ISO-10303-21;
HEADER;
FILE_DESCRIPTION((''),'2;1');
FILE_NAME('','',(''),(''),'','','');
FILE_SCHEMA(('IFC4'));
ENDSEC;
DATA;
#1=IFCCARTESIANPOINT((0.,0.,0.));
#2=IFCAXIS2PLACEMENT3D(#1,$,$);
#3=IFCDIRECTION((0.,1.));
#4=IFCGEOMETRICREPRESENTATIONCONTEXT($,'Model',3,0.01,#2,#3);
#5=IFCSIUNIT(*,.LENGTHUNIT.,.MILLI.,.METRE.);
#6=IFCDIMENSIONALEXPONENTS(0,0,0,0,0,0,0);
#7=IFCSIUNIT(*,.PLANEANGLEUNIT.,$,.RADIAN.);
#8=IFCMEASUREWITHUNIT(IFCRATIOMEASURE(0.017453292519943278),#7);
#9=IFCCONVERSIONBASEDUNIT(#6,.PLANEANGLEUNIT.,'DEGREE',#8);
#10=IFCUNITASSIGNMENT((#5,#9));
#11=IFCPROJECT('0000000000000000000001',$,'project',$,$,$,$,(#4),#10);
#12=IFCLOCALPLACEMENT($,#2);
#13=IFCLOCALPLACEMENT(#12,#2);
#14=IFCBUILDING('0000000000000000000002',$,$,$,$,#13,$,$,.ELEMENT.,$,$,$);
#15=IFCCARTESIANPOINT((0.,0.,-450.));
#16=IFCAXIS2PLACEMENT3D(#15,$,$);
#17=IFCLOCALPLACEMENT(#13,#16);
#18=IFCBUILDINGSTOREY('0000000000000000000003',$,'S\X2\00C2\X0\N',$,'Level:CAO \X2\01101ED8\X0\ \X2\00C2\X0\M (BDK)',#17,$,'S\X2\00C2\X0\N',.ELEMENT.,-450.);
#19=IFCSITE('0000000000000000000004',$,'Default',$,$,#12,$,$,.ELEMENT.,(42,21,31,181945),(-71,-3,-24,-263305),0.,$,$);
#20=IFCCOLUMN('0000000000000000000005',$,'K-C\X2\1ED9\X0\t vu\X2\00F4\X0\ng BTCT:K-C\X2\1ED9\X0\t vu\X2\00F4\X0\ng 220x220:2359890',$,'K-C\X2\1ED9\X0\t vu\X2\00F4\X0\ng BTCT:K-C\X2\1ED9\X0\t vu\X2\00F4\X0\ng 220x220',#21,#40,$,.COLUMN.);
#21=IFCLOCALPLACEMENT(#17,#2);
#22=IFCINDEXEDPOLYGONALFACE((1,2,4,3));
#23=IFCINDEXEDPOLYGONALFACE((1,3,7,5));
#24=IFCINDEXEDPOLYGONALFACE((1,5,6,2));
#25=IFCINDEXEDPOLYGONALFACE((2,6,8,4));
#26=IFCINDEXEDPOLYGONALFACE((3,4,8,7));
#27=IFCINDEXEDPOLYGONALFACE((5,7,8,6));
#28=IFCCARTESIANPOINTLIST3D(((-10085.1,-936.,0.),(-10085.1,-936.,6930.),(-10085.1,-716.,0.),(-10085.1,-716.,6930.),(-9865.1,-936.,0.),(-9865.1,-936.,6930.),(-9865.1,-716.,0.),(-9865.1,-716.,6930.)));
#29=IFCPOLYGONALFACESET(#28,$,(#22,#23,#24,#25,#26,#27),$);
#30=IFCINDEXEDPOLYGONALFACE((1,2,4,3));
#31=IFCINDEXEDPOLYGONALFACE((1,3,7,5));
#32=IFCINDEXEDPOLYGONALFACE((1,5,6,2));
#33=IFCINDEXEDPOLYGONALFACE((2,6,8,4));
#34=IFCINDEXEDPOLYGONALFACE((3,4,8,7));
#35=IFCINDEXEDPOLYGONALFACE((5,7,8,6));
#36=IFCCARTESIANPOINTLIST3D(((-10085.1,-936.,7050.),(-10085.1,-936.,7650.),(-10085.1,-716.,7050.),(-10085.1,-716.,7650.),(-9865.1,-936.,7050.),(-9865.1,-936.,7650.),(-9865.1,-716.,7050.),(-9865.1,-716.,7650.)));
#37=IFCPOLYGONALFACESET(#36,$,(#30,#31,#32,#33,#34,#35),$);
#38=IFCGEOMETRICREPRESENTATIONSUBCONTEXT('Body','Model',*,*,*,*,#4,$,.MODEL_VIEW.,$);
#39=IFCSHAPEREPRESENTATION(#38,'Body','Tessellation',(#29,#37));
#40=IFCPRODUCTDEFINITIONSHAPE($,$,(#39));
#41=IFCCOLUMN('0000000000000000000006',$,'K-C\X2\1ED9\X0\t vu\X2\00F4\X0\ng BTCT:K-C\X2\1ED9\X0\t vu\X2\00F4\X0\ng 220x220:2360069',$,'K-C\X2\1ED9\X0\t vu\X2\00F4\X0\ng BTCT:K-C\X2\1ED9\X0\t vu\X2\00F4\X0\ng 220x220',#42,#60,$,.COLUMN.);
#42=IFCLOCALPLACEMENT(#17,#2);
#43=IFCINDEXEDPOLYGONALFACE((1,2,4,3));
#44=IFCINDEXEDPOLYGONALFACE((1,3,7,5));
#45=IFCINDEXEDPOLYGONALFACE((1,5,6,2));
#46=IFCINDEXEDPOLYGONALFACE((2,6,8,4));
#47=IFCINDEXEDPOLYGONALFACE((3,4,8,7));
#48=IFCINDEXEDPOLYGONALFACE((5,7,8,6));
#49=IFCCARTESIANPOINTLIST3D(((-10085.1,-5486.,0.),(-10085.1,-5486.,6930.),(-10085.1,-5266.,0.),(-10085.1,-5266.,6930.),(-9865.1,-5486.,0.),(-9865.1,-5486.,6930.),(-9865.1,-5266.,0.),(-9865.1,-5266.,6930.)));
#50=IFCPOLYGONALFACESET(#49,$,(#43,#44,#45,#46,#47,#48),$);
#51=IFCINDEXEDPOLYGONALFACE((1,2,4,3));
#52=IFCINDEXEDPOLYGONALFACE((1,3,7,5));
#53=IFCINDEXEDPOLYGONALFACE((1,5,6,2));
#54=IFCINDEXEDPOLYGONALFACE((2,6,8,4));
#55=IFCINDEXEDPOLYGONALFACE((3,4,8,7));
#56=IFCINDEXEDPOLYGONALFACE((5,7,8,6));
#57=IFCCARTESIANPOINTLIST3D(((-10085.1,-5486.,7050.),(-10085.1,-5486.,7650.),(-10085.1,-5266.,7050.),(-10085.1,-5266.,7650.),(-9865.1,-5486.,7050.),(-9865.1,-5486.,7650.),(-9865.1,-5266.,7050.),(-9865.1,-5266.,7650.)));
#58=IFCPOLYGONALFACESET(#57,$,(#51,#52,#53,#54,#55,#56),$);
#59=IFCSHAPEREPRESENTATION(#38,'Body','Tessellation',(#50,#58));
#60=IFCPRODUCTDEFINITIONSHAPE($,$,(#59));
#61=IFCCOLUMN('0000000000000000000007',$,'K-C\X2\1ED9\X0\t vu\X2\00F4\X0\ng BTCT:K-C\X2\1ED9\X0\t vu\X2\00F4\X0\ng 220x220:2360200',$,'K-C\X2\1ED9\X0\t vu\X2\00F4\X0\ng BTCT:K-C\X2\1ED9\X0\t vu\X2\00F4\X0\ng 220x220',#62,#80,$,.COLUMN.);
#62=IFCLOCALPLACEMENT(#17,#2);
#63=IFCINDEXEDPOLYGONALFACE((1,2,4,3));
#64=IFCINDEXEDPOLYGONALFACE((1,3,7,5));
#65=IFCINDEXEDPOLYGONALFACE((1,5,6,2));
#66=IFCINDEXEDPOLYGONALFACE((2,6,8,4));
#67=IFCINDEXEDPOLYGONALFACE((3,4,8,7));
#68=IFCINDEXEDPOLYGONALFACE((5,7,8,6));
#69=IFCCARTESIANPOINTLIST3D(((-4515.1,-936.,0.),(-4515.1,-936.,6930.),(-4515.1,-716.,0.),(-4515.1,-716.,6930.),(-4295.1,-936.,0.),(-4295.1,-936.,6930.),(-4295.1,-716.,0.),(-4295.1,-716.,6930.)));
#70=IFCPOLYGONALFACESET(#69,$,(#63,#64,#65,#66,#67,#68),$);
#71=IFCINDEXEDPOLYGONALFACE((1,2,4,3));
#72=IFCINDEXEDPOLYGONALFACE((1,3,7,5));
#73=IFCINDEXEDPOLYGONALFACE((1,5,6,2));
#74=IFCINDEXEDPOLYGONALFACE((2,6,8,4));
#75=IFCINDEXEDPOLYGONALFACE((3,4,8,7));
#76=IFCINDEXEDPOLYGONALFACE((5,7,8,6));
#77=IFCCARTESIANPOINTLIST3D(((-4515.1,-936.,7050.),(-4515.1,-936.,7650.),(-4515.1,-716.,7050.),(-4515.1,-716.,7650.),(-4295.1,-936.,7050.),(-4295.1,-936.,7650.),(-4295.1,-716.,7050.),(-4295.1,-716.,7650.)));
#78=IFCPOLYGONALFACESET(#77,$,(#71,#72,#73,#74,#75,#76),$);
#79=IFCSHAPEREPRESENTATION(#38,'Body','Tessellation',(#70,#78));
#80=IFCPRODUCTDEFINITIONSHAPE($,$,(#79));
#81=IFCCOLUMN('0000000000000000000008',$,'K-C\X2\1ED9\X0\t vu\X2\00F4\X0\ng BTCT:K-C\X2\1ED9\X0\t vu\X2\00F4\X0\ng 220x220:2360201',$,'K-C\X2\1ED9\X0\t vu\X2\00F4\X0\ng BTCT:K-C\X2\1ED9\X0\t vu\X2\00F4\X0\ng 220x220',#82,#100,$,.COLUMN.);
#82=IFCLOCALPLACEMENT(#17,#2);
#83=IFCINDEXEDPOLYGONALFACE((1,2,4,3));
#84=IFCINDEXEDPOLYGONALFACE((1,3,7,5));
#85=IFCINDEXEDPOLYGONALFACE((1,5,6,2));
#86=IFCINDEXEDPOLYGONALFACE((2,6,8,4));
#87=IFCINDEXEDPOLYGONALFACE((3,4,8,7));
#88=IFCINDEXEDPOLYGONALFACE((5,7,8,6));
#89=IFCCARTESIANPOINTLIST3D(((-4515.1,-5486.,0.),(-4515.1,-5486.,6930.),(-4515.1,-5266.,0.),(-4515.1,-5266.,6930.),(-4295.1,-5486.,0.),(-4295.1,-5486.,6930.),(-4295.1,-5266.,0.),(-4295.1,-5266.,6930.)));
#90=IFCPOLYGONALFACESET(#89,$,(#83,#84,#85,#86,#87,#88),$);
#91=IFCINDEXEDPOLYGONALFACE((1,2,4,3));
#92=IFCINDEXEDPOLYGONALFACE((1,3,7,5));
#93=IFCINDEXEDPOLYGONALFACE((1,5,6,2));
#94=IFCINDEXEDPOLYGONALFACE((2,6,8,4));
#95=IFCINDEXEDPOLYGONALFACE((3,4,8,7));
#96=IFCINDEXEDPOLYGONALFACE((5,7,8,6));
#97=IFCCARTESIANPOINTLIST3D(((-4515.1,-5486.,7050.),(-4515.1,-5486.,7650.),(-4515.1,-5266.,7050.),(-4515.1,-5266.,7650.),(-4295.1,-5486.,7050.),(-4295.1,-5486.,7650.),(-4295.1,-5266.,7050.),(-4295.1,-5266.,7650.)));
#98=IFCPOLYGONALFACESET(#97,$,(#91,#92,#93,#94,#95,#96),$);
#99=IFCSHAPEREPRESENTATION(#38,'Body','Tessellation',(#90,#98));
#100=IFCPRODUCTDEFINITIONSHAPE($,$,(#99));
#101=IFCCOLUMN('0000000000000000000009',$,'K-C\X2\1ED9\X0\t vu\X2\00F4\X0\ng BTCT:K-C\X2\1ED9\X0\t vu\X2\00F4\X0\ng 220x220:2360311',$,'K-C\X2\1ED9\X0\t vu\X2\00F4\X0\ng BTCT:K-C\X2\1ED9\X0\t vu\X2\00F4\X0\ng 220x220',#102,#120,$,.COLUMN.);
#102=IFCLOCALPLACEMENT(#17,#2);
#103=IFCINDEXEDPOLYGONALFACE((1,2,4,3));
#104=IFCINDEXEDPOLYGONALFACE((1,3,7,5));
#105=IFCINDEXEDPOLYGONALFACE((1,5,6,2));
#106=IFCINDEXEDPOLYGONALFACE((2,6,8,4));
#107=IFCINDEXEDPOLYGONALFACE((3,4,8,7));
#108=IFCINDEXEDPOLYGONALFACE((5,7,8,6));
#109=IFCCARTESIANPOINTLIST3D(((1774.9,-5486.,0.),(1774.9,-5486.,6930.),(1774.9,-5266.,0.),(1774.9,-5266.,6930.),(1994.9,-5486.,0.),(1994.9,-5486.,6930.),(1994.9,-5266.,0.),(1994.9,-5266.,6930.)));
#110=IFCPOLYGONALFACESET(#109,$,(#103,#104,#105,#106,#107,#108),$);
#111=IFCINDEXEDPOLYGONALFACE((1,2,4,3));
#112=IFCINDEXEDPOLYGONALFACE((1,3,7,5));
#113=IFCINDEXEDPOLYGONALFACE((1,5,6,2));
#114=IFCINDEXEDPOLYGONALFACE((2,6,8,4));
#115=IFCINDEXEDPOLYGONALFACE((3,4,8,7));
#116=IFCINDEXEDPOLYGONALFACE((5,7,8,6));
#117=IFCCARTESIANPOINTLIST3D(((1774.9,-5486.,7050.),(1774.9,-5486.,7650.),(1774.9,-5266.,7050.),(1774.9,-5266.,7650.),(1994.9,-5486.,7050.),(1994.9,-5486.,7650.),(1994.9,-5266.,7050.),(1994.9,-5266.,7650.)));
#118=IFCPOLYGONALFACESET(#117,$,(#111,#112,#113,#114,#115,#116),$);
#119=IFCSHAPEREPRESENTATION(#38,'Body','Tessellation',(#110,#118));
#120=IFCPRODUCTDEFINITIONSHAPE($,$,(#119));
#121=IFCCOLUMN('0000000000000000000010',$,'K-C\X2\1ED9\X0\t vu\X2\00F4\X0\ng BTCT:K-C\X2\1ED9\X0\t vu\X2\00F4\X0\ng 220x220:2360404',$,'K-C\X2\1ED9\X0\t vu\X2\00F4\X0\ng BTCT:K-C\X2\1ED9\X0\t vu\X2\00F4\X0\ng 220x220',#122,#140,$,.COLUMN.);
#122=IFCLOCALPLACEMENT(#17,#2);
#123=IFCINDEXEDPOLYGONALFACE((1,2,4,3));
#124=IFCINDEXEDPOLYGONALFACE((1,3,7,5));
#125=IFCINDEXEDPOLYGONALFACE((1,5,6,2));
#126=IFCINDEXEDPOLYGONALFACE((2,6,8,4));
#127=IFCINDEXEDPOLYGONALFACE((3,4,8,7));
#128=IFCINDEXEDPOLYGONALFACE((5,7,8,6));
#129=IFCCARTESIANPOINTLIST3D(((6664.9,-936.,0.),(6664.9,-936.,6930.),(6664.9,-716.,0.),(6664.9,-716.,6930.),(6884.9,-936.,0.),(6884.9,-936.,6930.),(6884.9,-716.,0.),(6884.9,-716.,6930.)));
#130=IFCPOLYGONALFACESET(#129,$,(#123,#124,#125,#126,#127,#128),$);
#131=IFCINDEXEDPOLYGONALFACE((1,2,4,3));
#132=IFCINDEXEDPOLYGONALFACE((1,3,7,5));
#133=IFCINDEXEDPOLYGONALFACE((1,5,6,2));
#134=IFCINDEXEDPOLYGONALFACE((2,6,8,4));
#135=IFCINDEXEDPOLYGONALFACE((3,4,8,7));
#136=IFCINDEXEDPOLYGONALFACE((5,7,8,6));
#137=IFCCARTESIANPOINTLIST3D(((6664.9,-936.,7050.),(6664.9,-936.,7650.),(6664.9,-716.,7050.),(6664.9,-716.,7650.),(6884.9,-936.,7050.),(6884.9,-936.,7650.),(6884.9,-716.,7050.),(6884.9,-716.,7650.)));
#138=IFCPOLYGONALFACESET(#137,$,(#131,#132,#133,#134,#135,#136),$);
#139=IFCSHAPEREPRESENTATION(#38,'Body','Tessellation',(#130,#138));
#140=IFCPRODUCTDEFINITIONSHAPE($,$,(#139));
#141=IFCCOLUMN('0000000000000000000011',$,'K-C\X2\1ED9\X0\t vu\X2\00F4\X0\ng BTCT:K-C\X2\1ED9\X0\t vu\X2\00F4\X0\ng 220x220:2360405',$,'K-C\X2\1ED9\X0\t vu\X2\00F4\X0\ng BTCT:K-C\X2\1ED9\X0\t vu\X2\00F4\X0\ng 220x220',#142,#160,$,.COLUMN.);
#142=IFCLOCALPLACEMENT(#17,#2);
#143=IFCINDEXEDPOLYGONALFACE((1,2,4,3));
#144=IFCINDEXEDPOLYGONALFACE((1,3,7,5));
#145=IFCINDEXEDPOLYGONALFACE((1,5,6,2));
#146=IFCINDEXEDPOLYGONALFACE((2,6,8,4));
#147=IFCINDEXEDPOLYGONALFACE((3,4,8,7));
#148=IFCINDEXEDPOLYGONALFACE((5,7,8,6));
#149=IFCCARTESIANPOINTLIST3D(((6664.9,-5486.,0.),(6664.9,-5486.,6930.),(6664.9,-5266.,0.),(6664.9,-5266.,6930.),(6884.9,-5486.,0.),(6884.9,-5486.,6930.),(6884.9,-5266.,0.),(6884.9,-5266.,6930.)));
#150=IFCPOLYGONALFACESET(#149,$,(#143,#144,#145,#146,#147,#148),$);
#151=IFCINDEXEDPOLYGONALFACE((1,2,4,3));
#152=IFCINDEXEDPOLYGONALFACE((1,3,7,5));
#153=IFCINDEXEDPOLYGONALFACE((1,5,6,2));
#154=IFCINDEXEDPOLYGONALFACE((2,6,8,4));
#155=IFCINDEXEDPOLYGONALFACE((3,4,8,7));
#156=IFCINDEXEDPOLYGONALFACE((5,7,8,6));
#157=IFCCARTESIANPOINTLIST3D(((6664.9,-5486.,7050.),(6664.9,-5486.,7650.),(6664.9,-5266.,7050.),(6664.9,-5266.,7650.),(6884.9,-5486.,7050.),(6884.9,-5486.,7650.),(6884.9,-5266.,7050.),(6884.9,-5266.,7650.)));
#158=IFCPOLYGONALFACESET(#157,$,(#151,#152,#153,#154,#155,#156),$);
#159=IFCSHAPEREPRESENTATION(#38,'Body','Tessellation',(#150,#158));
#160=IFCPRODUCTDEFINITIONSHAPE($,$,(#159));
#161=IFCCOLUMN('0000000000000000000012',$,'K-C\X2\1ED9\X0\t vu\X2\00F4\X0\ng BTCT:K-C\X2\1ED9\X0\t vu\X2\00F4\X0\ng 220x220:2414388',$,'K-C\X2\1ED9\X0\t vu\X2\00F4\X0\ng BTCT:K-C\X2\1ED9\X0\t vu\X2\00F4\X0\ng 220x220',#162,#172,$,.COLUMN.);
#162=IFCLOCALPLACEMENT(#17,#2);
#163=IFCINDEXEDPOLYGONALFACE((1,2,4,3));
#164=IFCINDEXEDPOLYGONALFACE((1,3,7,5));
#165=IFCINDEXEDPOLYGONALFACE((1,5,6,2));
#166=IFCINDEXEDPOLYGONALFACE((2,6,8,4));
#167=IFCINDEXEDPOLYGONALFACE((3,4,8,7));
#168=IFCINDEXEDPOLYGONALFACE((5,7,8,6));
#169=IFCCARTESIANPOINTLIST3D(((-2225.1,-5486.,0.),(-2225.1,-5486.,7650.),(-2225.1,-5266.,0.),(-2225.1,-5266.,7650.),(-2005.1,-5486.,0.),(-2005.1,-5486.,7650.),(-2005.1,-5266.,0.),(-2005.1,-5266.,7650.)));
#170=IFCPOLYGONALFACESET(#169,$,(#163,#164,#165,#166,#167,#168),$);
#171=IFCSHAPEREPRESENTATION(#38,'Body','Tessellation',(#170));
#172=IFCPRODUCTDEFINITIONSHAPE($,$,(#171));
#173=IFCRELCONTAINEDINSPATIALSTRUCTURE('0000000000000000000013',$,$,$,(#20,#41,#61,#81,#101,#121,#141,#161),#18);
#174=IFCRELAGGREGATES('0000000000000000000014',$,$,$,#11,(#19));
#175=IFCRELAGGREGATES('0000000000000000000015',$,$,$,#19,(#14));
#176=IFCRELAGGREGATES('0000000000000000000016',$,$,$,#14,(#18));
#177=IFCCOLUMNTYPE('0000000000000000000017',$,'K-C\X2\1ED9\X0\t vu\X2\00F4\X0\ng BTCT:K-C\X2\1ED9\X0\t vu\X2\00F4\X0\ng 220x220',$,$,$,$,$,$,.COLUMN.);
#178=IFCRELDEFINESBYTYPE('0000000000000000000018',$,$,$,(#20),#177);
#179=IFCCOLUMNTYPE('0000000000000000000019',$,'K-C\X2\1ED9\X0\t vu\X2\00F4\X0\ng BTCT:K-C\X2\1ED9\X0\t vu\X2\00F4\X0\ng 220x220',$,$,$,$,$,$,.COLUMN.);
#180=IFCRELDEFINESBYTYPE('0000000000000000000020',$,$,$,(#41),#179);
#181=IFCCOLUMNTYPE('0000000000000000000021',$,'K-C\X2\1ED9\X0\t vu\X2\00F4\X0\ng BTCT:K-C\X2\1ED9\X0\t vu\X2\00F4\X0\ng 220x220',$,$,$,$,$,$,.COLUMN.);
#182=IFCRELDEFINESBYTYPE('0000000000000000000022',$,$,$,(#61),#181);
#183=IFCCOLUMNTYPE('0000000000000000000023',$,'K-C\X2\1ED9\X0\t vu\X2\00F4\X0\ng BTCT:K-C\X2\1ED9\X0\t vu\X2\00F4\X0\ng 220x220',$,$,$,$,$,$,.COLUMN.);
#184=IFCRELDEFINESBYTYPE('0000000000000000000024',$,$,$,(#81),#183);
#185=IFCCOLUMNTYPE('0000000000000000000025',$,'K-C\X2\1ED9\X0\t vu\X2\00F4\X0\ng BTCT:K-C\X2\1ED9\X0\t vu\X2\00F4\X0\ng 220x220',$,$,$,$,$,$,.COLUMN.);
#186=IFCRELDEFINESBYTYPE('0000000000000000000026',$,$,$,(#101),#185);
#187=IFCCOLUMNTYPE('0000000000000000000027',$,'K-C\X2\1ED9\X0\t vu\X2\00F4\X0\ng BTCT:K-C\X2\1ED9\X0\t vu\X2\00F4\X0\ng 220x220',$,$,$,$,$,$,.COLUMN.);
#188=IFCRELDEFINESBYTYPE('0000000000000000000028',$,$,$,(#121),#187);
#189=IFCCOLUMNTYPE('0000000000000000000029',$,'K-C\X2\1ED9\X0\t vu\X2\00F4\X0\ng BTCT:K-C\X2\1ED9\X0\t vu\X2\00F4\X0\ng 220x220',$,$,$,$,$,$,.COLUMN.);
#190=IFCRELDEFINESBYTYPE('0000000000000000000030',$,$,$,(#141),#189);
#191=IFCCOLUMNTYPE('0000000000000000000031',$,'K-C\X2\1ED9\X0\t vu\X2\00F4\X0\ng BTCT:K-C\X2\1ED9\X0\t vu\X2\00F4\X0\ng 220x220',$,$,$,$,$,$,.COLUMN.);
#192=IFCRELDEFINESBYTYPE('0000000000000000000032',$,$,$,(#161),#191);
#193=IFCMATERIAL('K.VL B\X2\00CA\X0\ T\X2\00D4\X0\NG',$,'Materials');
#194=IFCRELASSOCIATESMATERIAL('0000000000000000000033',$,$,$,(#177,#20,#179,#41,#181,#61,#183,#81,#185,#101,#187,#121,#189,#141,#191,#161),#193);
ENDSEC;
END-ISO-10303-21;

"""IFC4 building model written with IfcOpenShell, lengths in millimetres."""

from ifc_helpers import new_model, entity, si_unit, converted_unit, direction, frame, origin, place, context, subcontext, project, spatial, indexed_curve, outline, extrude, source, transform, mapped, material, type_object, type_shapes, element, save


model = new_model("IFC4")

# Units and contexts
model_context = context("Model", 3, precision=0.01, world=origin(), true_north=direction((0.0, 1.0)))
body_context = subcontext(model_context, "Body", "Model", "MODEL_VIEW")
ifc_project = project(units=[si_unit("LENGTHUNIT", "METRE", prefix="MILLI"), converted_unit("PLANEANGLEUNIT", "DEGREE", entity("IfcRatioMeasure", 0.017453292519943278), si_unit("PLANEANGLEUNIT", "RADIAN"), dimensions=[0, 0, 0, 0, 0, 0, 0])], contexts=[model_context])

# Site, building, storey
site_placement = place(None, origin())
site = spatial("IfcSite", under=ifc_project, at=site_placement, Name="Default", CompositionType="ELEMENT", RefLatitude=(42, 21, 31, 181945), RefLongitude=(-71, -3, -24, -263305), RefElevation=0.0)
building_placement = place(site_placement, origin())
building = spatial("IfcBuilding", under=site, at=building_placement, CompositionType="ELEMENT")
storey_placement = place(building_placement, frame((0.0, 0.0, -450.0)))
storey = spatial("IfcBuildingStorey", under=building, at=storey_placement, Name="SÂN", ObjectType="Level:CAO ĐỘ ÂM (BDK)", LongName="SÂN", CompositionType="ELEMENT", Elevation=-450.0)

# Columns
ifc_material_1 = material(Name="K.VL BÊ TÔNG", Category="Materials")
column_type_1 = type_object("IfcColumnType", Name="K-Cột vuông BTCT:K-Cột vuông 220x220", PredefinedType="COLUMN", material=ifc_material_1)
shared_shape_1 = source(origin(), body_context, "Body", "SweptSolid", [
    extrude(outline(indexed_curve([(-110.0, -110.0), (110.0, -110.0), (110.0, 110.0), (-110.0, 110.0), (-110.0, -110.0)], self_intersect=False)), frame((-9975.1, -826.0, -450.0), z_axis=(0.0, 0.0, 1.0), x_axis=(0.0, -1.0, 0.0)), (0.0, 0.0, 1.0), 6930.0),
    extrude(outline(indexed_curve([(-110.0, -110.0), (110.0, -110.0), (110.0, 110.0), (-110.0, 110.0), (-110.0, -110.0)], self_intersect=False)), frame((-9975.1, -826.0, 6600.0), z_axis=(0.0, 0.0, 1.0), x_axis=(0.0, -1.0, 0.0)), (0.0, 0.0, 1.0), 600.0),
])
type_shapes(column_type_1, [shared_shape_1])
column_1_placement = place(storey_placement, frame((0.0, 0.0, 450.0)))
element("IfcColumn", 1, at=column_1_placement, inside=storey, type_object=column_type_1, material=ifc_material_1, Name="K-Cột vuông BTCT:K-Cột vuông 220x220:2359890", ObjectType="K-Cột vuông BTCT:K-Cột vuông 220x220", PredefinedType="COLUMN", context=body_context, shape_type="MappedRepresentation", body=[
    mapped(shared_shape_1, transform((0.0, 0.0, 0.0), scale=1.0)),
])
column_type_2 = type_object("IfcColumnType", Name="K-Cột vuông BTCT:K-Cột vuông 220x220", PredefinedType="COLUMN", material=ifc_material_1)
shared_shape_2 = source(origin(), body_context, "Body", "SweptSolid", [
    extrude(outline(indexed_curve([(-110.0, -110.0), (110.0, -110.0), (110.0, 110.0), (-110.0, 110.0), (-110.0, -110.0)], self_intersect=False)), frame((-9975.1, -5376.0, -450.0), z_axis=(0.0, 0.0, 1.0), x_axis=(0.0, -1.0, 0.0)), (0.0, 0.0, 1.0), 6930.0),
    extrude(outline(indexed_curve([(-110.0, -110.0), (110.0, -110.0), (110.0, 110.0), (-110.0, 110.0), (-110.0, -110.0)], self_intersect=False)), frame((-9975.1, -5376.0, 6600.0), z_axis=(0.0, 0.0, 1.0), x_axis=(0.0, -1.0, 0.0)), (0.0, 0.0, 1.0), 600.0),
])
type_shapes(column_type_2, [shared_shape_2])
column_2_placement = place(storey_placement, frame((0.0, 0.0, 450.0)))
element("IfcColumn", 2, at=column_2_placement, inside=storey, type_object=column_type_2, material=ifc_material_1, Name="K-Cột vuông BTCT:K-Cột vuông 220x220:2360069", ObjectType="K-Cột vuông BTCT:K-Cột vuông 220x220", PredefinedType="COLUMN", context=body_context, shape_type="MappedRepresentation", body=[
    mapped(shared_shape_2, transform((0.0, 0.0, 0.0), scale=1.0)),
])
column_type_3 = type_object("IfcColumnType", Name="K-Cột vuông BTCT:K-Cột vuông 220x220", PredefinedType="COLUMN", material=ifc_material_1)
shared_shape_3 = source(origin(), body_context, "Body", "SweptSolid", [
    extrude(outline(indexed_curve([(-110.0, -110.0), (110.0, -110.0), (110.0, 110.0), (-110.0, 110.0), (-110.0, -110.0)], self_intersect=False)), frame((-4405.1, -826.0, -450.0), z_axis=(0.0, 0.0, 1.0), x_axis=(0.0, -1.0, 0.0)), (0.0, 0.0, 1.0), 6930.0),
    extrude(outline(indexed_curve([(-110.0, -110.0), (110.0, -110.0), (110.0, 110.0), (-110.0, 110.0), (-110.0, -110.0)], self_intersect=False)), frame((-4405.1, -826.0, 6600.0), z_axis=(0.0, 0.0, 1.0), x_axis=(0.0, -1.0, 0.0)), (0.0, 0.0, 1.0), 600.0),
])
type_shapes(column_type_3, [shared_shape_3])
column_3_placement = place(storey_placement, frame((0.0, 0.0, 450.0)))
element("IfcColumn", 3, at=column_3_placement, inside=storey, type_object=column_type_3, material=ifc_material_1, Name="K-Cột vuông BTCT:K-Cột vuông 220x220:2360200", ObjectType="K-Cột vuông BTCT:K-Cột vuông 220x220", PredefinedType="COLUMN", context=body_context, shape_type="MappedRepresentation", body=[
    mapped(shared_shape_3, transform((0.0, 0.0, 0.0), scale=1.0)),
])
column_type_4 = type_object("IfcColumnType", Name="K-Cột vuông BTCT:K-Cột vuông 220x220", PredefinedType="COLUMN", material=ifc_material_1)
shared_shape_4 = source(origin(), body_context, "Body", "SweptSolid", [
    extrude(outline(indexed_curve([(-110.0, -110.0), (110.0, -110.0), (110.0, 110.0), (-110.0, 110.0), (-110.0, -110.0)], self_intersect=False)), frame((-4405.1, -5376.0, -450.0), z_axis=(0.0, 0.0, 1.0), x_axis=(0.0, -1.0, 0.0)), (0.0, 0.0, 1.0), 6930.0),
    extrude(outline(indexed_curve([(-110.0, -110.0), (110.0, -110.0), (110.0, 110.0), (-110.0, 110.0), (-110.0, -110.0)], self_intersect=False)), frame((-4405.1, -5376.0, 6600.0), z_axis=(0.0, 0.0, 1.0), x_axis=(0.0, -1.0, 0.0)), (0.0, 0.0, 1.0), 600.0),
])
type_shapes(column_type_4, [shared_shape_4])
column_4_placement = place(storey_placement, frame((0.0, 0.0, 450.0)))
element("IfcColumn", 4, at=column_4_placement, inside=storey, type_object=column_type_4, material=ifc_material_1, Name="K-Cột vuông BTCT:K-Cột vuông 220x220:2360201", ObjectType="K-Cột vuông BTCT:K-Cột vuông 220x220", PredefinedType="COLUMN", context=body_context, shape_type="MappedRepresentation", body=[
    mapped(shared_shape_4, transform((0.0, 0.0, 0.0), scale=1.0)),
])
column_type_5 = type_object("IfcColumnType", Name="K-Cột vuông BTCT:K-Cột vuông 220x220", PredefinedType="COLUMN", material=ifc_material_1)
shared_shape_5 = source(origin(), body_context, "Body", "SweptSolid", [
    extrude(outline(indexed_curve([(-110.0, -110.0), (110.0, -110.0), (110.0, 110.0), (-110.0, 110.0), (-110.0, -110.0)], self_intersect=False)), frame((1884.9, -5376.0, -450.0), z_axis=(0.0, 0.0, 1.0), x_axis=(0.0, -1.0, 0.0)), (0.0, 0.0, 1.0), 6930.0),
    extrude(outline(indexed_curve([(-110.0, -110.0), (110.0, -110.0), (110.0, 110.0), (-110.0, 110.0), (-110.0, -110.0)], self_intersect=False)), frame((1884.9, -5376.0, 6600.0), z_axis=(0.0, 0.0, 1.0), x_axis=(0.0, -1.0, 0.0)), (0.0, 0.0, 1.0), 600.0),
])
type_shapes(column_type_5, [shared_shape_5])
column_5_placement = place(storey_placement, frame((0.0, 0.0, 450.0)))
element("IfcColumn", 5, at=column_5_placement, inside=storey, type_object=column_type_5, material=ifc_material_1, Name="K-Cột vuông BTCT:K-Cột vuông 220x220:2360311", ObjectType="K-Cột vuông BTCT:K-Cột vuông 220x220", PredefinedType="COLUMN", context=body_context, shape_type="MappedRepresentation", body=[
    mapped(shared_shape_5, transform((0.0, 0.0, 0.0), scale=1.0)),
])
column_type_6 = type_object("IfcColumnType", Name="K-Cột vuông BTCT:K-Cột vuông 220x220", PredefinedType="COLUMN", material=ifc_material_1)
shared_shape_6 = source(origin(), body_context, "Body", "SweptSolid", [
    extrude(outline(indexed_curve([(-110.0, -110.0), (110.0, -110.0), (110.0, 110.0), (-110.0, 110.0), (-110.0, -110.0)], self_intersect=False)), frame((6774.9, -826.0, -450.0), z_axis=(0.0, 0.0, 1.0), x_axis=(0.0, -1.0, 0.0)), (0.0, 0.0, 1.0), 6930.0),
    extrude(outline(indexed_curve([(-110.0, -110.0), (110.0, -110.0), (110.0, 110.0), (-110.0, 110.0), (-110.0, -110.0)], self_intersect=False)), frame((6774.9, -826.0, 6600.0), z_axis=(0.0, 0.0, 1.0), x_axis=(0.0, -1.0, 0.0)), (0.0, 0.0, 1.0), 600.0),
])
type_shapes(column_type_6, [shared_shape_6])
column_6_placement = place(storey_placement, frame((0.0, 0.0, 450.0)))
element("IfcColumn", 6, at=column_6_placement, inside=storey, type_object=column_type_6, material=ifc_material_1, Name="K-Cột vuông BTCT:K-Cột vuông 220x220:2360404", ObjectType="K-Cột vuông BTCT:K-Cột vuông 220x220", PredefinedType="COLUMN", context=body_context, shape_type="MappedRepresentation", body=[
    mapped(shared_shape_6, transform((0.0, 0.0, 0.0), scale=1.0)),
])
column_type_7 = type_object("IfcColumnType", Name="K-Cột vuông BTCT:K-Cột vuông 220x220", PredefinedType="COLUMN", material=ifc_material_1)
shared_shape_7 = source(origin(), body_context, "Body", "SweptSolid", [
    extrude(outline(indexed_curve([(-110.0, -110.0), (110.0, -110.0), (110.0, 110.0), (-110.0, 110.0), (-110.0, -110.0)], self_intersect=False)), frame((6774.9, -5376.0, -450.0), z_axis=(0.0, 0.0, 1.0), x_axis=(0.0, -1.0, 0.0)), (0.0, 0.0, 1.0), 6930.0),
    extrude(outline(indexed_curve([(-110.0, -110.0), (110.0, -110.0), (110.0, 110.0), (-110.0, 110.0), (-110.0, -110.0)], self_intersect=False)), frame((6774.9, -5376.0, 6600.0), z_axis=(0.0, 0.0, 1.0), x_axis=(0.0, -1.0, 0.0)), (0.0, 0.0, 1.0), 600.0),
])
type_shapes(column_type_7, [shared_shape_7])
column_7_placement = place(storey_placement, frame((0.0, 0.0, 450.0)))
element("IfcColumn", 7, at=column_7_placement, inside=storey, type_object=column_type_7, material=ifc_material_1, Name="K-Cột vuông BTCT:K-Cột vuông 220x220:2360405", ObjectType="K-Cột vuông BTCT:K-Cột vuông 220x220", PredefinedType="COLUMN", context=body_context, shape_type="MappedRepresentation", body=[
    mapped(shared_shape_7, transform((0.0, 0.0, 0.0), scale=1.0)),
])
column_type_8 = type_object("IfcColumnType", Name="K-Cột vuông BTCT:K-Cột vuông 220x220", PredefinedType="COLUMN", material=ifc_material_1)
shared_shape_8 = source(origin(), body_context, "Body", "SweptSolid", [
    extrude(outline(indexed_curve([(-110.0, -110.0), (110.0, -110.0), (110.0, 110.0), (-110.0, 110.0), (-110.0, -110.0)], self_intersect=False)), frame((-2115.1, -5376.0, -450.0), z_axis=(0.0, 0.0, 1.0), x_axis=(0.0, -1.0, 0.0)), (0.0, 0.0, 1.0), 7650.0),
])
type_shapes(column_type_8, [shared_shape_8])
column_8_placement = place(storey_placement, frame((0.0, 0.0, 450.0)))
element("IfcColumn", 8, at=column_8_placement, inside=storey, type_object=column_type_8, material=ifc_material_1, Name="K-Cột vuông BTCT:K-Cột vuông 220x220:2414388", ObjectType="K-Cột vuông BTCT:K-Cột vuông 220x220", PredefinedType="COLUMN", context=body_context, shape_type="MappedRepresentation", body=[
    mapped(shared_shape_8, transform((0.0, 0.0, 0.0), scale=1.0)),
])

save(model, "model.ifc")
